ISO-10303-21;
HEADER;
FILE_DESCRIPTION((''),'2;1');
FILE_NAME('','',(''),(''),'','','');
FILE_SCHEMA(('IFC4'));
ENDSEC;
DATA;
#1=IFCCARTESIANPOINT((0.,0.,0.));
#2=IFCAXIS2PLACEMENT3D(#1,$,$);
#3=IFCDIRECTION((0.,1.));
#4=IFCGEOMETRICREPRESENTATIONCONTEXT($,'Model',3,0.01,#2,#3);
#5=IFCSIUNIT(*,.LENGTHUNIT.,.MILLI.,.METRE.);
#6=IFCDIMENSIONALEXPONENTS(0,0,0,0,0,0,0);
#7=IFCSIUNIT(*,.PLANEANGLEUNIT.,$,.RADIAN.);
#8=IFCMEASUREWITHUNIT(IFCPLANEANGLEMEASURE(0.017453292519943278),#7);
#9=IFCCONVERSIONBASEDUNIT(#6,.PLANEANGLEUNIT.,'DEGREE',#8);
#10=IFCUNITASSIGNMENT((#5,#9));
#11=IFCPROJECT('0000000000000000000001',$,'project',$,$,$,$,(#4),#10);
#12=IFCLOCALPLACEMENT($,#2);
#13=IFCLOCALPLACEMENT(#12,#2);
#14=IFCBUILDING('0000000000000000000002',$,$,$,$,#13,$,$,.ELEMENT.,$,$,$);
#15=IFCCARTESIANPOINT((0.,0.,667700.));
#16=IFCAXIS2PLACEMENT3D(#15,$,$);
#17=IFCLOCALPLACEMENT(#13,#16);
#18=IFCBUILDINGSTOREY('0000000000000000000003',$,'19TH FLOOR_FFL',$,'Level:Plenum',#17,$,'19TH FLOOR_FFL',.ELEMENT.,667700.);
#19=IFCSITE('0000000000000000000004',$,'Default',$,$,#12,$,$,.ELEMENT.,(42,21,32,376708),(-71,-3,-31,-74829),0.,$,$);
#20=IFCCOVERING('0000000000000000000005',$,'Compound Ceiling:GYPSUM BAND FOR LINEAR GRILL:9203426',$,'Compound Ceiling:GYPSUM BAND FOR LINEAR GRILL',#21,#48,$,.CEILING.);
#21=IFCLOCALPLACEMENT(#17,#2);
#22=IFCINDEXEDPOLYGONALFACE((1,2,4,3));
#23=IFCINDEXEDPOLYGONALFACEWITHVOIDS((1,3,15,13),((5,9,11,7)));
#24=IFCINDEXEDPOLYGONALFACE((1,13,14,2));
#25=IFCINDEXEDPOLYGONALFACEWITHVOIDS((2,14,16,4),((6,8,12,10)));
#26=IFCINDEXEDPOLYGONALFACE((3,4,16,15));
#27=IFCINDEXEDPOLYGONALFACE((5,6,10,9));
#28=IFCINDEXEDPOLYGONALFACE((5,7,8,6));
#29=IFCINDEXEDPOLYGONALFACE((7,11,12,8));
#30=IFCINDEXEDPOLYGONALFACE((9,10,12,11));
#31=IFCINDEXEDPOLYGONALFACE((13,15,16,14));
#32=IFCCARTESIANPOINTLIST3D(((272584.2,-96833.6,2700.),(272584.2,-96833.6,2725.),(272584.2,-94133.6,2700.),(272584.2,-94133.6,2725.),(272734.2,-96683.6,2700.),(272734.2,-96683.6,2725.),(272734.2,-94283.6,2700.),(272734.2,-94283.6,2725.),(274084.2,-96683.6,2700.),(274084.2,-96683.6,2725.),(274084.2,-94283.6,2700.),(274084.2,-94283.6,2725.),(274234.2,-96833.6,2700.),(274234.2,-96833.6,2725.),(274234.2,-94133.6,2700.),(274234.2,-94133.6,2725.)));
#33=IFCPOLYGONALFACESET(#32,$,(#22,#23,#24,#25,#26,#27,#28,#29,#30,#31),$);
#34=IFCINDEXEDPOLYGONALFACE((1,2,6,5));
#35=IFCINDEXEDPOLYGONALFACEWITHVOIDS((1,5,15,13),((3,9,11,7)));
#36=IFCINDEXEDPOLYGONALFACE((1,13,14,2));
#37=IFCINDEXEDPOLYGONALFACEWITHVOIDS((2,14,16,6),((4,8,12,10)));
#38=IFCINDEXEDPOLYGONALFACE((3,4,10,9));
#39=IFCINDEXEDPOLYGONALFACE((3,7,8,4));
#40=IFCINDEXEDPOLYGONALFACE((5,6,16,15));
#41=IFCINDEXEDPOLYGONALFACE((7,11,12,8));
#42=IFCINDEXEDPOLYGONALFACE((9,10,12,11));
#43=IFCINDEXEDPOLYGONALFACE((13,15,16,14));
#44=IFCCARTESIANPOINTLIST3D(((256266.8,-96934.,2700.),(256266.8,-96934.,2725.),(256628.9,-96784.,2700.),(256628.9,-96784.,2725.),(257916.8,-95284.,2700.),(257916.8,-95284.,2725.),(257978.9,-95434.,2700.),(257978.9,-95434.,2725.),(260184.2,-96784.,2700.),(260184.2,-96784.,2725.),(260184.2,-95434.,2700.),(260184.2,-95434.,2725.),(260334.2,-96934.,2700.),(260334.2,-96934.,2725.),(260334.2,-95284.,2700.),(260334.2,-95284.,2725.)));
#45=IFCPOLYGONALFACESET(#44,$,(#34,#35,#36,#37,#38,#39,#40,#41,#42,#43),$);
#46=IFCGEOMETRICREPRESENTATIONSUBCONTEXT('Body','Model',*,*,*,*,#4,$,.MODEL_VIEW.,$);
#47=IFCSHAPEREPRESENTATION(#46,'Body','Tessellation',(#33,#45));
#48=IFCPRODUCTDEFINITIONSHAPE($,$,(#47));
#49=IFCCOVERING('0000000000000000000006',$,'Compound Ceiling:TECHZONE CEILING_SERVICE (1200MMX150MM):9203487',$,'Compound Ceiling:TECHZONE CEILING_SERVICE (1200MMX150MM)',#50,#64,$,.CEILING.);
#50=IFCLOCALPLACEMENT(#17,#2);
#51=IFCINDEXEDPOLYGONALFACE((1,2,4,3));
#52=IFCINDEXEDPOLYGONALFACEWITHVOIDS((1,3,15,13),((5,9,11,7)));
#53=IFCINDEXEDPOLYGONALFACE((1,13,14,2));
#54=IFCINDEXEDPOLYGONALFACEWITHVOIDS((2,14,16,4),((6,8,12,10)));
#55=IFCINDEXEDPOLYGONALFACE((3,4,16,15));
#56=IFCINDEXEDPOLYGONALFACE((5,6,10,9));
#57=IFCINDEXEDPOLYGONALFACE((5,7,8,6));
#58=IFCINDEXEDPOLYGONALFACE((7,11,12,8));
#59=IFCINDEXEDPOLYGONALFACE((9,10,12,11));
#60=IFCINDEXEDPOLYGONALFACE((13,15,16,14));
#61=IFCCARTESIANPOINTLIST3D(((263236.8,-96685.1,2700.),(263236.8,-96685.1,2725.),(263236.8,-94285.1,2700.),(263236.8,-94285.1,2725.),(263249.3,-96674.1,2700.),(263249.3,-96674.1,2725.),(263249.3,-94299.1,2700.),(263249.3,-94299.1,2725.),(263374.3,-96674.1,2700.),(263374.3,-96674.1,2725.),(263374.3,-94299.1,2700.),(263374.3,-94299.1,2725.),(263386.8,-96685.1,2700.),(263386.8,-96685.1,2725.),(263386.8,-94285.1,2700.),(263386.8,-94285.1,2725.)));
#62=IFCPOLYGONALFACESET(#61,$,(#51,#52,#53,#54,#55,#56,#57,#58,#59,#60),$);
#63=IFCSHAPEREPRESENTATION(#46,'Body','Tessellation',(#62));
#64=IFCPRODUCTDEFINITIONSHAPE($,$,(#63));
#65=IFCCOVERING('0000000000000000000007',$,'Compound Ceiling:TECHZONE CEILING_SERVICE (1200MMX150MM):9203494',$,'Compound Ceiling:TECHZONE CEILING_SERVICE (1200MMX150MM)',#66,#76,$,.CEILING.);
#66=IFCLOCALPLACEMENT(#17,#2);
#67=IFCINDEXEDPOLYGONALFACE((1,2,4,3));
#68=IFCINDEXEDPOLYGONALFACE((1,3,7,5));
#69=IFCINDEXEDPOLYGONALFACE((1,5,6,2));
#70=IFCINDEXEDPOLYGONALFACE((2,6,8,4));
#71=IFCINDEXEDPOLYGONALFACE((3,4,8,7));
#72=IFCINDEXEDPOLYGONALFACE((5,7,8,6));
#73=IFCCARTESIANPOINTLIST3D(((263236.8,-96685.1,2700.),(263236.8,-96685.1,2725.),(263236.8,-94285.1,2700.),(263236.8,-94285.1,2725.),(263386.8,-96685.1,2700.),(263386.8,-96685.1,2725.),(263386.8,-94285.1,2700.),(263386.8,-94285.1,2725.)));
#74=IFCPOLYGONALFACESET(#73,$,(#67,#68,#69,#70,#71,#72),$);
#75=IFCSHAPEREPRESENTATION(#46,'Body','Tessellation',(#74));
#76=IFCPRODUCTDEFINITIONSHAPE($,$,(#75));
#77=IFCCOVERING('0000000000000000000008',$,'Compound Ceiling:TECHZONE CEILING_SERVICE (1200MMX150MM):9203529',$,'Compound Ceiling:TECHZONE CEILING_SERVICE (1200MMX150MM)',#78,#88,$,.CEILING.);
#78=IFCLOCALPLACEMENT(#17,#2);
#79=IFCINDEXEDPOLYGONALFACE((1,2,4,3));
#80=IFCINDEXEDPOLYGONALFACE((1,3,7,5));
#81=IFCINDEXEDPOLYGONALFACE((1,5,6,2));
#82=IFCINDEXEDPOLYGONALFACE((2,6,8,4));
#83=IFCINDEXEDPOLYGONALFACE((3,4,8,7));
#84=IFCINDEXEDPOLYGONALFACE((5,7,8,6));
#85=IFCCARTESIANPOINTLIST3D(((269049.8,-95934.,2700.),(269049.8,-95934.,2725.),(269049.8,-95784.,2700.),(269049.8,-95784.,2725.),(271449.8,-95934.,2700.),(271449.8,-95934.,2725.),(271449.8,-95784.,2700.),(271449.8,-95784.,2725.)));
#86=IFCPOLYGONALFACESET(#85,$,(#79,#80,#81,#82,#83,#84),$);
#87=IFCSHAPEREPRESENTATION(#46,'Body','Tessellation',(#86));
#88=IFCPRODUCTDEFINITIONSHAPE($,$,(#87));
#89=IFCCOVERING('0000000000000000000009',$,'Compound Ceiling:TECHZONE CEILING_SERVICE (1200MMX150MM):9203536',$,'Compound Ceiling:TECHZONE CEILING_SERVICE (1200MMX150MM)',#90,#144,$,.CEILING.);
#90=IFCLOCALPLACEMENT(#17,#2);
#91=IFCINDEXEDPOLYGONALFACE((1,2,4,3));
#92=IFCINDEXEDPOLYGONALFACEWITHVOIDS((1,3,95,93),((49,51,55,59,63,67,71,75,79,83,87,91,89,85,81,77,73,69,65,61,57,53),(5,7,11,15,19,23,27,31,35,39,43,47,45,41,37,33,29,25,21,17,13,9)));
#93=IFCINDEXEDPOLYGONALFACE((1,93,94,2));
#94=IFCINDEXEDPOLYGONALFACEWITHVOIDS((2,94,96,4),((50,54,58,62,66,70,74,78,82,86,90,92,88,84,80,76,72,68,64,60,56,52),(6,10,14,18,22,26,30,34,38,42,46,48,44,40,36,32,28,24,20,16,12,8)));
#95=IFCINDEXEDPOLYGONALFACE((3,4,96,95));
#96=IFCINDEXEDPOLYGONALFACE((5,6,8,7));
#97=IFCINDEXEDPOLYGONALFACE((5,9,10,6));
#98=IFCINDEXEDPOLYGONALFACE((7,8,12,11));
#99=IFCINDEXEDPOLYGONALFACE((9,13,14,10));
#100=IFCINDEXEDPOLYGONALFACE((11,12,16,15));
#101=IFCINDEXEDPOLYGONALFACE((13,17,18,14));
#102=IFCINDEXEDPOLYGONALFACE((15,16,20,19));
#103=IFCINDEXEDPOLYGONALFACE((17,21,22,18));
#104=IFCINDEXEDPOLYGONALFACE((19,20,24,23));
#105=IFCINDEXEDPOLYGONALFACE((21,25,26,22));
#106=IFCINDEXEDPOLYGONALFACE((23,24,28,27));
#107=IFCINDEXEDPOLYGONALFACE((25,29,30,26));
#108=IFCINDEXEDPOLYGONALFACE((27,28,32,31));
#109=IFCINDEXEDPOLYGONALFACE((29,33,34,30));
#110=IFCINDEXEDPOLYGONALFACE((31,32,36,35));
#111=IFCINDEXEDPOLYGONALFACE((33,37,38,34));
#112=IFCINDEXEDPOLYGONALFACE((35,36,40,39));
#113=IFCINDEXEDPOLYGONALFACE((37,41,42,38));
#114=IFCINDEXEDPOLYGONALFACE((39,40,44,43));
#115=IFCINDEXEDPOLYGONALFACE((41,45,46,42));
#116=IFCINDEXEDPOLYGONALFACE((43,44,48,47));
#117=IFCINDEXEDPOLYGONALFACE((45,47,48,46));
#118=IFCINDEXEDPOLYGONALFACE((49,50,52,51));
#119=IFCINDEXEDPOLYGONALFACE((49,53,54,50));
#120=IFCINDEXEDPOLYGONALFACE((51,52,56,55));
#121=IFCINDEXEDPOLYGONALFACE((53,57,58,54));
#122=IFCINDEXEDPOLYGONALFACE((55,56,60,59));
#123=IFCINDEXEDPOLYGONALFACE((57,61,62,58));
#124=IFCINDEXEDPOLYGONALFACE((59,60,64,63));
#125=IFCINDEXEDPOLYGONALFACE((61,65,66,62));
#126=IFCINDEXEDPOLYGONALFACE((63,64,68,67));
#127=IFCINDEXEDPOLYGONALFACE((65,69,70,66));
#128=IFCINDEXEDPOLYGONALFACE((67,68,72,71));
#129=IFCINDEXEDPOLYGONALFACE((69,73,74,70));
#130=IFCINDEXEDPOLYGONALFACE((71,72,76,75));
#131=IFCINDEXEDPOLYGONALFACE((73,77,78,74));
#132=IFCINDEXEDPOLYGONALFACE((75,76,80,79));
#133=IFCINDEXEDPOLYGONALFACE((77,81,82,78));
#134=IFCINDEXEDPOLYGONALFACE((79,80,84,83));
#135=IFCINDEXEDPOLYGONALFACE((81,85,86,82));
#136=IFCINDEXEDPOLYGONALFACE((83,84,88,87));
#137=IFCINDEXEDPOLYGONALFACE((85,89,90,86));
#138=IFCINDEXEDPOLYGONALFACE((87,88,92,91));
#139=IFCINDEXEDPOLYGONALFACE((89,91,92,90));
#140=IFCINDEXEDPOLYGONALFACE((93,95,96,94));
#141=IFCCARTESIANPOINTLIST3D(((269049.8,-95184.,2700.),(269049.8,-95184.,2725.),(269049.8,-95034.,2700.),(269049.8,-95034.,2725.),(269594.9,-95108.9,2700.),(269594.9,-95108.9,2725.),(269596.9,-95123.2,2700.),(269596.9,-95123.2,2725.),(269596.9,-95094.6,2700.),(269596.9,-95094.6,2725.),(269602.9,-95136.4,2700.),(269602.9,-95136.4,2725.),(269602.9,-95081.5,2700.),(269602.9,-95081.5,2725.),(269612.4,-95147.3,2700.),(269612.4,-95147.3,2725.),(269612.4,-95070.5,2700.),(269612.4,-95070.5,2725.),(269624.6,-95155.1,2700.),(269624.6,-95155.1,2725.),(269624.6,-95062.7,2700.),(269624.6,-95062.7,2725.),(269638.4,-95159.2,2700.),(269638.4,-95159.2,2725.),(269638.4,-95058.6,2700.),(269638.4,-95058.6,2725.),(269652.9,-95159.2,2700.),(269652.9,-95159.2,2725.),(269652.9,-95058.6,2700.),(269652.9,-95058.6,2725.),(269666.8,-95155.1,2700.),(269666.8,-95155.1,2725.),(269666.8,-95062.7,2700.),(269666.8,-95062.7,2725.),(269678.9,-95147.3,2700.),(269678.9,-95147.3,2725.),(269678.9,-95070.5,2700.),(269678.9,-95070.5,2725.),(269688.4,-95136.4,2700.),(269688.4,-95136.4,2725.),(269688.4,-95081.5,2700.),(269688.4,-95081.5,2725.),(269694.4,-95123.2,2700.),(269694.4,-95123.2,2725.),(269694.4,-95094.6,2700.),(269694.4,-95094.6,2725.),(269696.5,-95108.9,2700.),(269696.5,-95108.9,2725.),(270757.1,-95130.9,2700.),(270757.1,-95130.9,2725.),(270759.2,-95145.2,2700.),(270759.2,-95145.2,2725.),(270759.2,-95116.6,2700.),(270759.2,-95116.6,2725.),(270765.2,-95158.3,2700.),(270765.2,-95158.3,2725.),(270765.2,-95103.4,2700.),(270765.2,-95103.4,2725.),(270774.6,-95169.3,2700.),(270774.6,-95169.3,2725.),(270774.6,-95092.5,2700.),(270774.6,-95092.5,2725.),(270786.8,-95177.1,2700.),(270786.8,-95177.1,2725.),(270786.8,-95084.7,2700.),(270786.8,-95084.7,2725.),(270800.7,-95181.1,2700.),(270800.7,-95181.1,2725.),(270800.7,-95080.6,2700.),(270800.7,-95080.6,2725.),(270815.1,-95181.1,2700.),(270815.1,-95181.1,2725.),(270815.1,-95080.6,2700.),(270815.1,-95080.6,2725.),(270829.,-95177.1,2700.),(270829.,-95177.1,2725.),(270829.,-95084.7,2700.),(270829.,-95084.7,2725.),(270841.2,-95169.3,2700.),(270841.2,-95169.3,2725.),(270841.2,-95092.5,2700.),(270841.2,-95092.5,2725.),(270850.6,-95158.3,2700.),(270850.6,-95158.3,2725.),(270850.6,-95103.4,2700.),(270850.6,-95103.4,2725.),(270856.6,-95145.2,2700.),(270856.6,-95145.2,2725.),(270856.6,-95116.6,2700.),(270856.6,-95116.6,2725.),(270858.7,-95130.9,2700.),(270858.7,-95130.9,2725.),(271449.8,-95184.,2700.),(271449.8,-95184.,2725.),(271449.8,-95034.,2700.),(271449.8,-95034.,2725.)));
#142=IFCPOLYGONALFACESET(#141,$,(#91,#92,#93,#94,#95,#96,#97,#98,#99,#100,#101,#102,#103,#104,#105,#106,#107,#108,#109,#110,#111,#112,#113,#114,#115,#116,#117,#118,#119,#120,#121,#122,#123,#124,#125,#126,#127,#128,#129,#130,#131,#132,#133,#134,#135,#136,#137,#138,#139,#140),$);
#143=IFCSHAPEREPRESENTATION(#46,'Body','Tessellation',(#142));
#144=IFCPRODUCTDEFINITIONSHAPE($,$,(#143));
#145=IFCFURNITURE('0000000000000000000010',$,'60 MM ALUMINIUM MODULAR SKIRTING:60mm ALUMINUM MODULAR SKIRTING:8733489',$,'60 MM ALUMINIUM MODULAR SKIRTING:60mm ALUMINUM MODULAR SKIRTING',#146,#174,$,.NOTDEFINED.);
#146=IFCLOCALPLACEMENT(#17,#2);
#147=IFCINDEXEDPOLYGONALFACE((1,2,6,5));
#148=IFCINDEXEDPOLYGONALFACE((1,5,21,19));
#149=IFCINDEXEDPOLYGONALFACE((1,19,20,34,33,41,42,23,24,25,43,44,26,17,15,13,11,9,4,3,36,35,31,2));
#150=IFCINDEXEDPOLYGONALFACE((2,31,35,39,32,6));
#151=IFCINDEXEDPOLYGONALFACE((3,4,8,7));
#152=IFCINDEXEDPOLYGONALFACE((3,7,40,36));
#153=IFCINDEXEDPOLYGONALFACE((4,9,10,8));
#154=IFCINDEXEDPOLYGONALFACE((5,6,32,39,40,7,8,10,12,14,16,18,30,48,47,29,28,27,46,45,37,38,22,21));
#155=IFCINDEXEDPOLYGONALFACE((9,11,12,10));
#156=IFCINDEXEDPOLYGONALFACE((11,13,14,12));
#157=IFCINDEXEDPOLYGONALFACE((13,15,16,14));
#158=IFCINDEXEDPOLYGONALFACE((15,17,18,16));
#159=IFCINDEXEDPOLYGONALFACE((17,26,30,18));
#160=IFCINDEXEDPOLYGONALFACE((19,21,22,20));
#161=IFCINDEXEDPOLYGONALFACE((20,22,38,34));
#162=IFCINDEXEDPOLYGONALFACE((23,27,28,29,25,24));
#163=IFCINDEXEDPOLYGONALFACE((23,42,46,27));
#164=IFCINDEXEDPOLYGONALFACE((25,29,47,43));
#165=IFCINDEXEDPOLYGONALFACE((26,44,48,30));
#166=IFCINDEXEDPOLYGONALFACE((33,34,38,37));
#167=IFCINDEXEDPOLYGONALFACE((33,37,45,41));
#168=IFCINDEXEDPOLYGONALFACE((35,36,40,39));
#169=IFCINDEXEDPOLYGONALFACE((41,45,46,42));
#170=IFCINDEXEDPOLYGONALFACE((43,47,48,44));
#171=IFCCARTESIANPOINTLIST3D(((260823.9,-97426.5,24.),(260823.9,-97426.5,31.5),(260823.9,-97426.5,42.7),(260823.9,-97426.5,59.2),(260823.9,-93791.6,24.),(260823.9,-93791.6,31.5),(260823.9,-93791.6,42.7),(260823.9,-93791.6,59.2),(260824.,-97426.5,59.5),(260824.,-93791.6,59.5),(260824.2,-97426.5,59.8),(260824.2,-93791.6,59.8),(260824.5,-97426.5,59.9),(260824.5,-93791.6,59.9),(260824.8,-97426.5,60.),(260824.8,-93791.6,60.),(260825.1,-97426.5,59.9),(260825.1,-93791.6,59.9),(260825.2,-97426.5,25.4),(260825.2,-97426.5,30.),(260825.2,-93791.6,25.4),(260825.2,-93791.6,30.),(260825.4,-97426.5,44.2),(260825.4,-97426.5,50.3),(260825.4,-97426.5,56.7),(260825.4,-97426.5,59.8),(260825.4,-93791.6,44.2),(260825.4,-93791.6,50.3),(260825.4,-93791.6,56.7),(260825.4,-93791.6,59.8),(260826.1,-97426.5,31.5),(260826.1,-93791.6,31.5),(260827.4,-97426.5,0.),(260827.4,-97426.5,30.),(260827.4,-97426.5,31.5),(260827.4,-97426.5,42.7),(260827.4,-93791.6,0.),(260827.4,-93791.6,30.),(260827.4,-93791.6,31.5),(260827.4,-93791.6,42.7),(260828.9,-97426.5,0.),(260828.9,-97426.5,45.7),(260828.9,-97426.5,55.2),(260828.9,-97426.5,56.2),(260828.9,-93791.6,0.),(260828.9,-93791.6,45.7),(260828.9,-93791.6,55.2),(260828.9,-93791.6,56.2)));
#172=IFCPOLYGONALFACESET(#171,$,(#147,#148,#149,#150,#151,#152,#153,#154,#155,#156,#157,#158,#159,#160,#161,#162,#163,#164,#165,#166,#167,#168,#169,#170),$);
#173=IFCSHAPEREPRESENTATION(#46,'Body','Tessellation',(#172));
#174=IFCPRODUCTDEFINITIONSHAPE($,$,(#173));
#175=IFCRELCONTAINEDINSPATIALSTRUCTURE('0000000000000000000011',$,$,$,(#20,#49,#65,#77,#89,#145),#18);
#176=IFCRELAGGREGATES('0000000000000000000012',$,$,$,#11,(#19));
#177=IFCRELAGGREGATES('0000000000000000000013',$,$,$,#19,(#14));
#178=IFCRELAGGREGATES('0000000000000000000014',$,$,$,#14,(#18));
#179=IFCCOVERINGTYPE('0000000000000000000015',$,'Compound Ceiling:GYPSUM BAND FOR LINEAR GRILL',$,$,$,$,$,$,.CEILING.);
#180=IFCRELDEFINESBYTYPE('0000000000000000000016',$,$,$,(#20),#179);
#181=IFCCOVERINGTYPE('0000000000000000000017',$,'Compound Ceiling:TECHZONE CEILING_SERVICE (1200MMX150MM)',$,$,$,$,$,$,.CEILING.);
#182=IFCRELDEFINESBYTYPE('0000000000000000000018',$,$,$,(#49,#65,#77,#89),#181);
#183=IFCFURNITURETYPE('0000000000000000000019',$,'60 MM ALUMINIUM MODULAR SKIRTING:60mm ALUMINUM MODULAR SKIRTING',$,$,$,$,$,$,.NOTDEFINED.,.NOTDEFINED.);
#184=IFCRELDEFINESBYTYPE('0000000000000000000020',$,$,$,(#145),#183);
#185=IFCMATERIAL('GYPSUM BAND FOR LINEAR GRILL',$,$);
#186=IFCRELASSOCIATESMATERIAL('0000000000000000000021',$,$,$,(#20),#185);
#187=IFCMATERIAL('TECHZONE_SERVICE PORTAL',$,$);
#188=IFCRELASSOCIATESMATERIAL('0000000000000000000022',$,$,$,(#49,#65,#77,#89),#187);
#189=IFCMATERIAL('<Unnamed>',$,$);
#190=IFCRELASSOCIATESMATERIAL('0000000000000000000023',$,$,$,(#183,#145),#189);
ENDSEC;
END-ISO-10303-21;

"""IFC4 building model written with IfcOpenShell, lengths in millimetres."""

from ifc_helpers import new_model, entity, si_unit, converted_unit, direction, frame, origin, place, context, subcontext, project, spatial, line, arc, indexed_curve, outline, extrude, source, transform, mapped, material, type_object, type_shapes, element, save


model = new_model("IFC4")

# Units and contexts
model_context = context("Model", 3, precision=0.01, world=origin(), true_north=direction((0.0, 1.0)))
body_context = subcontext(model_context, "Body", "Model", "MODEL_VIEW")
ifc_project = project(units=[si_unit("LENGTHUNIT", "METRE", prefix="MILLI"), converted_unit("PLANEANGLEUNIT", "DEGREE", entity("IfcPlaneAngleMeasure", 0.017453292519943278), si_unit("PLANEANGLEUNIT", "RADIAN"), dimensions=[0, 0, 0, 0, 0, 0, 0])], contexts=[model_context])

# Site, building, storey
site_placement = place(None, origin())
site = spatial("IfcSite", under=ifc_project, at=site_placement, Name="Default", CompositionType="ELEMENT", RefLatitude=(42, 21, 32, 376708), RefLongitude=(-71, -3, -31, -74829), RefElevation=0.0)
building_placement = place(site_placement, origin())
building = spatial("IfcBuilding", under=site, at=building_placement, CompositionType="ELEMENT")
storey_placement = place(building_placement, frame((0.0, 0.0, 667700.0)))
storey = spatial("IfcBuildingStorey", under=building, at=storey_placement, Name="19TH FLOOR_FFL", ObjectType="Level:Plenum", LongName="19TH FLOOR_FFL", CompositionType="ELEMENT", Elevation=667700.0)

# Coverings
ifc_material_1 = material(Name="GYPSUM BAND FOR LINEAR GRILL")
covering_type_1 = type_object("IfcCoveringType", Name="Compound Ceiling:GYPSUM BAND FOR LINEAR GRILL", PredefinedType="CEILING")
covering_1_placement = place(storey_placement, origin())
element("IfcCovering", 1, at=covering_1_placement, inside=storey, type_object=covering_type_1, material=ifc_material_1, Name="Compound Ceiling:GYPSUM BAND FOR LINEAR GRILL:9203426", ObjectType="Compound Ceiling:GYPSUM BAND FOR LINEAR GRILL", PredefinedType="CEILING", context=body_context, shape_type="SweptSolid", body=[
    extrude(outline(indexed_curve([(-1350.0, -825.0), (1350.0, -825.0), (1350.0, 825.0), (-1350.0, 825.0), (-1350.0, -825.0)], self_intersect=False), holes=[indexed_curve([(-1200.0, -675.0), (-1200.0, 675.0), (1200.0, 675.0), (1200.0, -675.0), (-1200.0, -675.0)], self_intersect=False)]), frame((273409.2, -95483.6, 2700.0), z_axis=(0.0, 0.0, 1.0), x_axis=(0.0, -1.0, 0.0)), (0.0, 0.0, 1.0), 25.0),
    extrude(outline(indexed_curve([(-1621.2, -825.0), (796.2, -825.0), (2446.2, 825.0), (-1621.2, 825.0), (-1621.2, -825.0)], self_intersect=False), holes=[indexed_curve([(-1471.2, -675.0), (-1471.2, 675.0), (2084.1, 675.0), (734.1, -675.0), (-1471.2, -675.0)], self_intersect=False)]), frame((258713.0, -96109.0, 2700.0), z_axis=(0.0, 0.0, 1.0), x_axis=(-1.0, 0.0, 0.0)), (0.0, 0.0, 1.0), 25.0),
])
ifc_material_2 = material(Name="TECHZONE_SERVICE PORTAL")
covering_type_2 = type_object("IfcCoveringType", Name="Compound Ceiling:TECHZONE CEILING_SERVICE (1200MMX150MM)", PredefinedType="CEILING")
covering_2_placement = place(storey_placement, origin())
element("IfcCovering", 2, at=covering_2_placement, inside=storey, type_object=covering_type_2, material=ifc_material_2, Name="Compound Ceiling:TECHZONE CEILING_SERVICE (1200MMX150MM):9203487", ObjectType="Compound Ceiling:TECHZONE CEILING_SERVICE (1200MMX150MM)", PredefinedType="CEILING", context=body_context, shape_type="SweptSolid", body=[
    extrude(outline(indexed_curve([(-75.0, -1200.0), (75.0, -1200.0), (75.0, 1200.0), (-75.0, 1200.0), (-75.0, -1200.0)], self_intersect=False), holes=[indexed_curve([(62.5, 1189.0), (62.5, -1186.0), (-62.5, -1186.0), (-62.5, 1189.0), (62.5, 1189.0)], self_intersect=False)]), frame((263311.8, -95485.1, 2700.0), z_axis=(0.0, 0.0, 1.0), x_axis=(-1.0, 0.0, 0.0)), (0.0, 0.0, 1.0), 25.0),
])
covering_3_placement = place(storey_placement, origin())
element("IfcCovering", 3, at=covering_3_placement, inside=storey, type_object=covering_type_2, material=ifc_material_2, Name="Compound Ceiling:TECHZONE CEILING_SERVICE (1200MMX150MM):9203494", ObjectType="Compound Ceiling:TECHZONE CEILING_SERVICE (1200MMX150MM)", PredefinedType="CEILING", context=body_context, shape_type="SweptSolid", body=[
    extrude(outline(indexed_curve([(-1200.0, -75.0), (1200.0, -75.0), (1200.0, 75.0), (-1200.0, 75.0), (-1200.0, -75.0)], self_intersect=False)), frame((263311.8, -95485.1, 2700.0), z_axis=(0.0, 0.0, 1.0), x_axis=(0.0, 1.0, 0.0)), (0.0, 0.0, 1.0), 25.0),
])
covering_4_placement = place(storey_placement, origin())
element("IfcCovering", 4, at=covering_4_placement, inside=storey, type_object=covering_type_2, material=ifc_material_2, Name="Compound Ceiling:TECHZONE CEILING_SERVICE (1200MMX150MM):9203529", ObjectType="Compound Ceiling:TECHZONE CEILING_SERVICE (1200MMX150MM)", PredefinedType="CEILING", context=body_context, shape_type="SweptSolid", body=[
    extrude(outline(indexed_curve([(-1200.0, -75.0), (1200.0, -75.0), (1200.0, 75.0), (-1200.0, 75.0), (-1200.0, -75.0)], self_intersect=False)), frame((270249.8, -95859.0, 2700.0)), (0.0, 0.0, 1.0), 25.0),
])
covering_5_placement = place(storey_placement, origin())
element("IfcCovering", 5, at=covering_5_placement, inside=storey, type_object=covering_type_2, material=ifc_material_2, Name="Compound Ceiling:TECHZONE CEILING_SERVICE (1200MMX150MM):9203536", ObjectType="Compound Ceiling:TECHZONE CEILING_SERVICE (1200MMX150MM)", PredefinedType="CEILING", context=body_context, shape_type="SweptSolid", body=[
    extrude(outline(indexed_curve([(-75.0, -1200.0), (75.0, -1200.0), (75.0, 1200.0), (-75.0, 1200.0), (-75.0, -1200.0)], self_intersect=False), holes=[indexed_curve([(0.1, 553.3), (-50.7, 604.1), (0.1, 654.9), (50.9, 604.1)], segments=[arc(1, 2, 3), arc(3, 4, 1)], self_intersect=False), indexed_curve([(-21.9, -608.9), (-72.7, -558.1), (-21.9, -507.3), (28.9, -558.1)], segments=[arc(1, 2, 3), arc(3, 4, 1)], self_intersect=False)]), frame((270249.8, -95109.0, 2700.0), z_axis=(0.0, 0.0, 1.0), x_axis=(0.0, 1.0, 0.0)), (0.0, 0.0, 1.0), 25.0),
])

# Furniture
ifc_material_3 = material(Name="<Unnamed>")
furniture_type = type_object("IfcFurnitureType", Name="60 MM ALUMINIUM MODULAR SKIRTING:60mm ALUMINUM MODULAR SKIRTING", AssemblyPlace="NOTDEFINED", PredefinedType="NOTDEFINED", material=ifc_material_3)
shared_shape_1 = source(origin(), body_context, "Body", "SweptSolid", [
    extrude(outline(indexed_curve([(-18.5, -2.7), (-17.5, -2.7), (-19.0, 0.8), (-12.6, 0.8), (-6.5, 0.8), (-8.0, -2.7), (37.7, -2.7), (37.7, -1.2), (7.7, -1.2), (7.7, 1.0), (12.3, 1.0), (13.7, 2.4), (6.2, 2.4), (6.2, 0.2), (6.2, -1.2), (-5.0, -1.2), (-5.0, 2.4), (-21.4, 2.3), (-22.2, 1.8), (-22.0, 0.9)], segments=[line(1, 2, 3, 4, 5, 6, 7, 8, 9, 10, 11, 12, 13, 14, 15, 16, 17, 18), arc(18, 19, 20), line(20, 1)], self_intersect=False)), frame((0.0, -2.4, 37.7), z_axis=(1.0, 0.0, 0.0), x_axis=(0.0, 0.0, -1.0)), (0.0, 0.0, 1.0), 3634.8),
])
type_shapes(furniture_type, [shared_shape_1])
furniture_placement = place(storey_placement, frame((260823.9, -97426.5, 0.0), z_axis=(0.0, 0.0, 1.0), x_axis=(0.0, 1.0, 0.0)))
element("IfcFurniture", 6, at=furniture_placement, inside=storey, type_object=furniture_type, material=ifc_material_3, Name="60 MM ALUMINIUM MODULAR SKIRTING:60mm ALUMINUM MODULAR SKIRTING:8733489", ObjectType="60 MM ALUMINIUM MODULAR SKIRTING:60mm ALUMINUM MODULAR SKIRTING", PredefinedType="NOTDEFINED", context=body_context, shape_type="MappedRepresentation", body=[
    mapped(shared_shape_1, transform((0.0, 0.0, 0.0), scale=1.0)),
])

save(model, "model.ifc")
